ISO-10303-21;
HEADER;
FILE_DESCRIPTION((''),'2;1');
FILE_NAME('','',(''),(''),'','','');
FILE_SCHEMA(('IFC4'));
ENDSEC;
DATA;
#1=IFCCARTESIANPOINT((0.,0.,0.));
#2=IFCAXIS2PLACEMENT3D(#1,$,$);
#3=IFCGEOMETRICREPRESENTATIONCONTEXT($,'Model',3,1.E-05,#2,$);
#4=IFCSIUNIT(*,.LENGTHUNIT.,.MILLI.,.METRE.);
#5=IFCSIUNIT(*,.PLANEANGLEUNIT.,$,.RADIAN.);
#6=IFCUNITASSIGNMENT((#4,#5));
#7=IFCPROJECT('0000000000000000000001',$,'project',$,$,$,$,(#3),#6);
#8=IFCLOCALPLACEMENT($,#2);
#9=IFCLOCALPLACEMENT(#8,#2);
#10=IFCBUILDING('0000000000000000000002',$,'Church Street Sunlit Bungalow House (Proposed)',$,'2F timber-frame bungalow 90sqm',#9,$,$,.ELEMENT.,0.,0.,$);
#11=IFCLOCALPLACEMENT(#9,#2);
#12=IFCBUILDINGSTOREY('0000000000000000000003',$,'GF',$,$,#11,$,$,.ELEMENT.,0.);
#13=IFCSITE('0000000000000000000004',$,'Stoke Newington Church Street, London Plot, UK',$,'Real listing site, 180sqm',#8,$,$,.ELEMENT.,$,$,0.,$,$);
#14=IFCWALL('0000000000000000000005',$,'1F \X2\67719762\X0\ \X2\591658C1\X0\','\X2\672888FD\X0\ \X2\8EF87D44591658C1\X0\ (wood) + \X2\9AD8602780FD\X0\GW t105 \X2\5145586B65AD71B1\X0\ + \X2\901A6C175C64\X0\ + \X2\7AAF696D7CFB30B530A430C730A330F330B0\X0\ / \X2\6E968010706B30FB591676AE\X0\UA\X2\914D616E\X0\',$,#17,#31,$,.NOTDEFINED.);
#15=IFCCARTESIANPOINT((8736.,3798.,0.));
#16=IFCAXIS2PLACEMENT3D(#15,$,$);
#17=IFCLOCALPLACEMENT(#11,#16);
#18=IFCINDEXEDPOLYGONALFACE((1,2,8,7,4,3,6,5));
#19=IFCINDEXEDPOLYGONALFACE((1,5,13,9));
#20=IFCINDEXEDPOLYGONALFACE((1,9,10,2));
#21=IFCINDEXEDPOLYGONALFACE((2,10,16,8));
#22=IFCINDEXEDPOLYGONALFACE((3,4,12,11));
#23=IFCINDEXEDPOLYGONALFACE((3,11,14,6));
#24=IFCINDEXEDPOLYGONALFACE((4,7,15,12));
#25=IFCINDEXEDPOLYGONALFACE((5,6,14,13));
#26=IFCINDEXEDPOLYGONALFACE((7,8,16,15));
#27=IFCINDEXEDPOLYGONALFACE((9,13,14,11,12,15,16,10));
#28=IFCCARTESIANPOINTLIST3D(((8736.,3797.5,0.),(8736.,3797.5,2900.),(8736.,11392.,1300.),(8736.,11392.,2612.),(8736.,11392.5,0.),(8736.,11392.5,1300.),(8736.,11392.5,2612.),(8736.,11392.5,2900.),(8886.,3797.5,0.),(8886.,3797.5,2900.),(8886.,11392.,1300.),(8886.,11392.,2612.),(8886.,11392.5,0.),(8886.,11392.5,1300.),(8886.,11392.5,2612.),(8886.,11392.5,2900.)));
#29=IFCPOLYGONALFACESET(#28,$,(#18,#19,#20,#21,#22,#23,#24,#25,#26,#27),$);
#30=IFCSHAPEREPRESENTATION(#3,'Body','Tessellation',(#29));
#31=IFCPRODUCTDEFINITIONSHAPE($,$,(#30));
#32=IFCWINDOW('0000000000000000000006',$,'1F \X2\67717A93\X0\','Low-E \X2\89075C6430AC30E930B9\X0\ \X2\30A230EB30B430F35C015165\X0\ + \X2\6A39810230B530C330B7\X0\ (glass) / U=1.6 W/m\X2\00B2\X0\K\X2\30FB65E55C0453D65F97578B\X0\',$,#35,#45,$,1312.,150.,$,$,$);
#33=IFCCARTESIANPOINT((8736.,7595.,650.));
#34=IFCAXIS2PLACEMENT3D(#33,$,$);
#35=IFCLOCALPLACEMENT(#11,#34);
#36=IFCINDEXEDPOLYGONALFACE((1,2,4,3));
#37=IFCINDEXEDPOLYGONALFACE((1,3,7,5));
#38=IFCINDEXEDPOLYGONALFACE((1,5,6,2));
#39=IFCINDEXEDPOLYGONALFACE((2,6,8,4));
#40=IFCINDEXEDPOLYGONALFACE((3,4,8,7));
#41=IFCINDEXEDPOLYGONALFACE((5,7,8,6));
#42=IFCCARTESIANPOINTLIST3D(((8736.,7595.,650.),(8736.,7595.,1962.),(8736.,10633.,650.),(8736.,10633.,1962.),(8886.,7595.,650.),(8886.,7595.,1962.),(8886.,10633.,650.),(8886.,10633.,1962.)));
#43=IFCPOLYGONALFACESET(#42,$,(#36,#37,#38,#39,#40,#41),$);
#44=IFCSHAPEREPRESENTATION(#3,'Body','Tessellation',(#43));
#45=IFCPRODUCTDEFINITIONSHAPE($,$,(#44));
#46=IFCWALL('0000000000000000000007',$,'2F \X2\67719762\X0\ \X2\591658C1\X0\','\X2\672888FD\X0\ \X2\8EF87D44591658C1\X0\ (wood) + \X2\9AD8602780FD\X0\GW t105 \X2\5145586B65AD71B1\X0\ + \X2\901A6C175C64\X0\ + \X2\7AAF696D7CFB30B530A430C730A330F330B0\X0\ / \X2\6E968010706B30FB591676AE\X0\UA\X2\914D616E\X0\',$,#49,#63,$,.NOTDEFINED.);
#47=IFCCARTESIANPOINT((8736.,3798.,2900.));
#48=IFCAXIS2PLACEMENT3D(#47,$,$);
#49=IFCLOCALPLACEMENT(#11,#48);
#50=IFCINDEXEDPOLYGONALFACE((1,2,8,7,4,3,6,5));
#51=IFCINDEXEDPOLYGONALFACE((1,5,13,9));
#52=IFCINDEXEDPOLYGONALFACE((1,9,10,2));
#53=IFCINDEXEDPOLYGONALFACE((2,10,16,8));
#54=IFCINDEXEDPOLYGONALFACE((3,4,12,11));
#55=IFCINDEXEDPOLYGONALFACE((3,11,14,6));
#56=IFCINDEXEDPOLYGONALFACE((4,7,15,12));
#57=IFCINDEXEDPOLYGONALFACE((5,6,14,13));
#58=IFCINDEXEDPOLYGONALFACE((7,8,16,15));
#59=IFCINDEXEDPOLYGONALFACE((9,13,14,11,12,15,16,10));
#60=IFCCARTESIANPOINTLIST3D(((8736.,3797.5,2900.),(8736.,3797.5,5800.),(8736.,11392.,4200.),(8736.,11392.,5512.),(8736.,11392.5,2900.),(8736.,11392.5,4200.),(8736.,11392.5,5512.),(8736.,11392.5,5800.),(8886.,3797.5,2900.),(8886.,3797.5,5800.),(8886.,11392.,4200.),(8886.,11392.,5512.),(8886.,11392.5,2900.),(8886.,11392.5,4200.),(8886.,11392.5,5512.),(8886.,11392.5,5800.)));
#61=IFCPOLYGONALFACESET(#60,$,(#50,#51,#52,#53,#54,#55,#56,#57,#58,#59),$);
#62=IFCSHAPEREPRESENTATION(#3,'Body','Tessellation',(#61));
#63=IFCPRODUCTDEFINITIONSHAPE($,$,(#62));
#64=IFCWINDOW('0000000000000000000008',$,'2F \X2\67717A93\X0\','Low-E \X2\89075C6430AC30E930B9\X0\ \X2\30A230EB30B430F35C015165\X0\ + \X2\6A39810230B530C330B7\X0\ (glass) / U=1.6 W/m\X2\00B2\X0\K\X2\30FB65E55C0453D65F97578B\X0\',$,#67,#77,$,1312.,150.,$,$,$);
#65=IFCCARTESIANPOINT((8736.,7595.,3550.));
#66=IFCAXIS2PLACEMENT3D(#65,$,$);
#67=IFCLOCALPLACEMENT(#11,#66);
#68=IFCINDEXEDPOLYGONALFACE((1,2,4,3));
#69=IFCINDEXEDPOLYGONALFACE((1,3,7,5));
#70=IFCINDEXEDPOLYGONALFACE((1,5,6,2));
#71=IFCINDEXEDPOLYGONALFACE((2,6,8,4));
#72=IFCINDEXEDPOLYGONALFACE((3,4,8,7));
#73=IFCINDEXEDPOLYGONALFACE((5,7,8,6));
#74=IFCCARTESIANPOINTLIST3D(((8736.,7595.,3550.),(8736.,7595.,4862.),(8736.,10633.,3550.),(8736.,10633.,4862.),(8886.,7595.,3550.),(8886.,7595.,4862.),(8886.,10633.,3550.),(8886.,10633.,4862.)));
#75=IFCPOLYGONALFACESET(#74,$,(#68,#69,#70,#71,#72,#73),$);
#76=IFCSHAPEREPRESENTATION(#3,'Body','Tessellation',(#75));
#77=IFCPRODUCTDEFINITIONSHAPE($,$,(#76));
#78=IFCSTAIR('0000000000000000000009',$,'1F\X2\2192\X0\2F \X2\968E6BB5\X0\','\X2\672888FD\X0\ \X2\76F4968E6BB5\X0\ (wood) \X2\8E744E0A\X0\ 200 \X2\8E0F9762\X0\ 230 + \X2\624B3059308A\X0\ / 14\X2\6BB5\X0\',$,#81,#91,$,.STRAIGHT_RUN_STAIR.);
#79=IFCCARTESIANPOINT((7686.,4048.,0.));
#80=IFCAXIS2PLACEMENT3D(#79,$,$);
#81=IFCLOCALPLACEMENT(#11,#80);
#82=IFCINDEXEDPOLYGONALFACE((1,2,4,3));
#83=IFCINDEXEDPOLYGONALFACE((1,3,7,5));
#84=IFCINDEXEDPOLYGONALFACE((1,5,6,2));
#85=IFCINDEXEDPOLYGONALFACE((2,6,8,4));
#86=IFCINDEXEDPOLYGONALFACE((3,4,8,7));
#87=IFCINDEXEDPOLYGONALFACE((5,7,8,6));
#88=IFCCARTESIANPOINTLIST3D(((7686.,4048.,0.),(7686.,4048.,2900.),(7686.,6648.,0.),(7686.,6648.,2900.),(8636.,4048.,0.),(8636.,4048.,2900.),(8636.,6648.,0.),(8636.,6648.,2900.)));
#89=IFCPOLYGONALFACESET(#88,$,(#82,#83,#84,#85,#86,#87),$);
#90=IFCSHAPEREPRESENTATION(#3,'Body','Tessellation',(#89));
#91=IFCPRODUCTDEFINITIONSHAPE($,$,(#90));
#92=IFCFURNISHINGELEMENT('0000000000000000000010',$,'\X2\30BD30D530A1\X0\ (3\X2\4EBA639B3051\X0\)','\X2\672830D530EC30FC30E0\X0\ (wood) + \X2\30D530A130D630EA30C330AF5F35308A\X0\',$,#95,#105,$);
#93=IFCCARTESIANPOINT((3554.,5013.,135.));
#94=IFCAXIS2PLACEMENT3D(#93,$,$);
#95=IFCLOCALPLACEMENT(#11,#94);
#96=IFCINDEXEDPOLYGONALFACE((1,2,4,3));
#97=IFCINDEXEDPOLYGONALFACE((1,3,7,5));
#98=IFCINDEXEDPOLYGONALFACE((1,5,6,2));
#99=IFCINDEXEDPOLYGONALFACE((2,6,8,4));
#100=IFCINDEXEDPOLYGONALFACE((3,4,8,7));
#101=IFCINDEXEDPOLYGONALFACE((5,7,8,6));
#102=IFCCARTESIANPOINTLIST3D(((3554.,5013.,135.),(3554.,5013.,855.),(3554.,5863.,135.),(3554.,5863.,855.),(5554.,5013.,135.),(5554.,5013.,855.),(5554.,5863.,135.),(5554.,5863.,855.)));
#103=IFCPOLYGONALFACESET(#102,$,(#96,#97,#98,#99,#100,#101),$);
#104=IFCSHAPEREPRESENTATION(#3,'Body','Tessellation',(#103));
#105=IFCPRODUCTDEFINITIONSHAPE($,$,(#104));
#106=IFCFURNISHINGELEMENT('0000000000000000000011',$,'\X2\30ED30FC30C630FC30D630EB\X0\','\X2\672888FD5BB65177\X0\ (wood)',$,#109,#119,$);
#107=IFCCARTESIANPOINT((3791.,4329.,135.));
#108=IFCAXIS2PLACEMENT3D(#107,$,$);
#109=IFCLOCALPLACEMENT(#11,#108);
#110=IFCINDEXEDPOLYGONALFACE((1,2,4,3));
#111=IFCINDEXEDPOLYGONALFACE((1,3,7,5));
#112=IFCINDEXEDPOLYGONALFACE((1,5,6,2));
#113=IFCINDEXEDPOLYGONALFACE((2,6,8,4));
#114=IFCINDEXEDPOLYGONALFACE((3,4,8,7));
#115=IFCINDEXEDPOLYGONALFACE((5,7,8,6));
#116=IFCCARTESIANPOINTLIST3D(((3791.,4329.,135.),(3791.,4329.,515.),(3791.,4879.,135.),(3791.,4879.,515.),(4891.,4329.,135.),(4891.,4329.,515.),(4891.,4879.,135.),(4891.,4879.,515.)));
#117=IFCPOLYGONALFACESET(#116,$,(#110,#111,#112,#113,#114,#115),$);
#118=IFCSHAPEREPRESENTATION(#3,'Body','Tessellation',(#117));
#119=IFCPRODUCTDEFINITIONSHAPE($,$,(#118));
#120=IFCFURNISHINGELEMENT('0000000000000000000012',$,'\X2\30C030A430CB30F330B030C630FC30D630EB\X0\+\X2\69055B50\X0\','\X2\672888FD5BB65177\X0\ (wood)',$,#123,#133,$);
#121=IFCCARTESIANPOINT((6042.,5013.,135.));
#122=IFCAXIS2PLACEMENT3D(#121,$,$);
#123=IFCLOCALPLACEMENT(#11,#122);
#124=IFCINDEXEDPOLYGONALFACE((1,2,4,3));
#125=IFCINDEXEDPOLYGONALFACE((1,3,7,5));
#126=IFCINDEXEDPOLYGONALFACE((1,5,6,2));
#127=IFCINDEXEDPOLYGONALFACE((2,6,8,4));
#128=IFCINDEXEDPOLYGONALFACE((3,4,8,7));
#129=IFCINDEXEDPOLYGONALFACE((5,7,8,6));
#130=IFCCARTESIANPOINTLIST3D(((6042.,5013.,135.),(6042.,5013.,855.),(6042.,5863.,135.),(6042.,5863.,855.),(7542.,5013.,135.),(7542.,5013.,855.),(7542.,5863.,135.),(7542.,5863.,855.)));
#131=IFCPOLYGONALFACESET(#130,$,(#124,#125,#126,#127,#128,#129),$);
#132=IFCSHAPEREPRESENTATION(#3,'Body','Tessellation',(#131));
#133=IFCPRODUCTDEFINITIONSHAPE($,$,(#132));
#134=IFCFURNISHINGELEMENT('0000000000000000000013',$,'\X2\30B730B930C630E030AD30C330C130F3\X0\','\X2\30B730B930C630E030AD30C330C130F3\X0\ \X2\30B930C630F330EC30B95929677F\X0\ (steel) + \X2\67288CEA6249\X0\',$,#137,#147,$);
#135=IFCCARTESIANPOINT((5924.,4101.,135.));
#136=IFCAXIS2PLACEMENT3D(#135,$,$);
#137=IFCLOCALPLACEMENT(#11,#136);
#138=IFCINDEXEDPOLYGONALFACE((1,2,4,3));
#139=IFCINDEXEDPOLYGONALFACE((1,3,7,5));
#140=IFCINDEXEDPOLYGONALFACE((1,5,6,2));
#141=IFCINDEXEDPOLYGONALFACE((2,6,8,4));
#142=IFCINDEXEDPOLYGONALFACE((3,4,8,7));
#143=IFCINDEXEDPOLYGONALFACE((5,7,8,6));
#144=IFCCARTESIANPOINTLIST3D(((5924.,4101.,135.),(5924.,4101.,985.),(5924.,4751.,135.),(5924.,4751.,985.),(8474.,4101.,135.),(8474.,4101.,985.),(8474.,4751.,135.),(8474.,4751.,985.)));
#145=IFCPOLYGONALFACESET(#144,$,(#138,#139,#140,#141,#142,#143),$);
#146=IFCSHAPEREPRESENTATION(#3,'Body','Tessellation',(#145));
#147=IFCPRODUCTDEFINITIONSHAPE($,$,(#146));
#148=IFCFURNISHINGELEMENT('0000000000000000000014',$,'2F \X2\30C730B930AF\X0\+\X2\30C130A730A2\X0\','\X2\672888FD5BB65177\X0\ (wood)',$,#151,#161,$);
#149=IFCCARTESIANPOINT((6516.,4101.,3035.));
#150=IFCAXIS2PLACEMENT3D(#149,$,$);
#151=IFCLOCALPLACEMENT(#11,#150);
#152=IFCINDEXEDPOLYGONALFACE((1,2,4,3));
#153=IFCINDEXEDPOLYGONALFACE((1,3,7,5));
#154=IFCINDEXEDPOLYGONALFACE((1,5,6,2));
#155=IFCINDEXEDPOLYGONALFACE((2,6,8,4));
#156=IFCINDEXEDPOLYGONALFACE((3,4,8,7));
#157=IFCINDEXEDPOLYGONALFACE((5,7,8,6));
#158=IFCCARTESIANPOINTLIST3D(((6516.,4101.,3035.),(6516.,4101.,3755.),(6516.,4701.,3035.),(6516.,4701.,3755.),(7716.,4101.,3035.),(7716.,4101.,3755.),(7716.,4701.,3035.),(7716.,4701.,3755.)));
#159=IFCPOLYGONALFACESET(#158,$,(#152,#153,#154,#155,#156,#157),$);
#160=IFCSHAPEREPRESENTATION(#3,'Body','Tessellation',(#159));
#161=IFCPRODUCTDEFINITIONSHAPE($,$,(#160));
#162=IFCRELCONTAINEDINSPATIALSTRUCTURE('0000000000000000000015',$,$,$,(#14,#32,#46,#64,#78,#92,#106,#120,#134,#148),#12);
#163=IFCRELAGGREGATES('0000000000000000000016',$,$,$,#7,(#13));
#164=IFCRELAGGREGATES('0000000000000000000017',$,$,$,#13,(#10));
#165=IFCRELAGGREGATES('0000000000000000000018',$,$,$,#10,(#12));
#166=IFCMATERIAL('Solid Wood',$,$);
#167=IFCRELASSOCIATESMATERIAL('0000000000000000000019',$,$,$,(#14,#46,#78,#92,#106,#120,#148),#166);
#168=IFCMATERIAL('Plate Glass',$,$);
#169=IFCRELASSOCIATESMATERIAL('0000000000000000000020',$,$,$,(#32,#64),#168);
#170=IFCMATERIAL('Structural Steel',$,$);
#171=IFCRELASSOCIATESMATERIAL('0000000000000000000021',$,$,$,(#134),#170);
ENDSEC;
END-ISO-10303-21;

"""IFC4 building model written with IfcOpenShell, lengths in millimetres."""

from ifc_helpers import new_model, si_unit, frame, frame_2d, origin, place, context, project, spatial, rectangle, extrude, material, element, fill, save


model = new_model("IFC4")

# Units and contexts
model_context = context("Model", 3, precision=1e-05, world=origin())
ifc_project = project(units=[si_unit("LENGTHUNIT", "METRE", prefix="MILLI"), si_unit("PLANEANGLEUNIT", "RADIAN")], contexts=[model_context])

# Site, building, storey
site_placement = place(None, origin())
site = spatial("IfcSite", under=ifc_project, at=site_placement, Name="Stoke Newington Church Street, London Plot, UK", ObjectType="Real listing site, 180sqm", CompositionType="ELEMENT", RefElevation=0.0)
building_placement = place(site_placement, origin())
building = spatial("IfcBuilding", under=site, at=building_placement, Name="Church Street Sunlit Bungalow House (Proposed)", ObjectType="2F timber-frame bungalow 90sqm", CompositionType="ELEMENT", ElevationOfRefHeight=0.0, ElevationOfTerrain=0.0)
storey_placement = place(building_placement, origin())
storey = spatial("IfcBuildingStorey", under=building, at=storey_placement, Name="GF", CompositionType="ELEMENT", Elevation=0.0)

# Wall, opening, window
ifc_material_1 = material(Name="Solid Wood")
wall_1_placement = place(storey_placement, frame((8736.0, 3798.0, 0.0)))
wall_1 = element("IfcWall", 1, at=wall_1_placement, inside=storey, material=ifc_material_1, Name="1F 東面 外壁", Description="木製 軸組外壁 (wood) + 高性能GW t105 充填断熱 + 通気層 + 窯業系サイディング / 準耐火・外皮UA配慮", PredefinedType="NOTDEFINED", context=model_context, shape_type="SweptSolid", body=[
    extrude(rectangle(XDim=150.0, YDim=7595.0, at=frame_2d((75.0, 3797.0))), frame((8736.0, 3798.0, 0.0)), (0.0, 0.0, 1.0), 2900.0),
])
opening_1_placement = place(storey_placement, frame((8736.0, 7595.0, 650.0)))
opening_1 = element("IfcOpeningElement", 2, at=opening_1_placement, cuts=wall_1, PredefinedType="NOTDEFINED", context=model_context, shape_type="SweptSolid", body=[
    extrude(rectangle(XDim=150.0, YDim=3038.0, at=frame_2d((75.0, 1519.0))), frame((8736.0, 7595.0, 650.0)), (0.0, 0.0, 1.0), 1312.0),
])
ifc_material_2 = material(Name="Plate Glass")
window_1_placement = place(storey_placement, frame((8736.0, 7595.0, 650.0)))
window_1 = element("IfcWindow", 3, at=window_1_placement, inside=storey, material=ifc_material_2, Name="1F 東窓", Description="Low-E 複層ガラス アルゴン封入 + 樹脂サッシ (glass) / U=1.6 W/m²K・日射取得型", OverallHeight=1312.0, OverallWidth=150.0, context=model_context, shape_type="SweptSolid", body=[
    extrude(rectangle(XDim=150.0, YDim=3038.0, at=frame_2d((75.0, 1519.0))), frame((8736.0, 7595.0, 650.0)), (0.0, 0.0, 1.0), 1312.0),
])
fill(opening_1, window_1)

# Wall, opening, window
wall_2_placement = place(storey_placement, frame((8736.0, 3798.0, 2900.0)))
wall_2 = element("IfcWall", 4, at=wall_2_placement, inside=storey, material=ifc_material_1, Name="2F 東面 外壁", Description="木製 軸組外壁 (wood) + 高性能GW t105 充填断熱 + 通気層 + 窯業系サイディング / 準耐火・外皮UA配慮", PredefinedType="NOTDEFINED", context=model_context, shape_type="SweptSolid", body=[
    extrude(rectangle(XDim=150.0, YDim=7595.0, at=frame_2d((75.0, 3797.0))), frame((8736.0, 3798.0, 2900.0)), (0.0, 0.0, 1.0), 2900.0),
])
opening_2_placement = place(storey_placement, frame((8736.0, 7595.0, 3550.0)))
opening_2 = element("IfcOpeningElement", 5, at=opening_2_placement, cuts=wall_2, PredefinedType="NOTDEFINED", context=model_context, shape_type="SweptSolid", body=[
    extrude(rectangle(XDim=150.0, YDim=3038.0, at=frame_2d((75.0, 1519.0))), frame((8736.0, 7595.0, 3550.0)), (0.0, 0.0, 1.0), 1312.0),
])
window_2_placement = place(storey_placement, frame((8736.0, 7595.0, 3550.0)))
window_2 = element("IfcWindow", 6, at=window_2_placement, inside=storey, material=ifc_material_2, Name="2F 東窓", Description="Low-E 複層ガラス アルゴン封入 + 樹脂サッシ (glass) / U=1.6 W/m²K・日射取得型", OverallHeight=1312.0, OverallWidth=150.0, context=model_context, shape_type="SweptSolid", body=[
    extrude(rectangle(XDim=150.0, YDim=3038.0, at=frame_2d((75.0, 1519.0))), frame((8736.0, 7595.0, 3550.0)), (0.0, 0.0, 1.0), 1312.0),
])
fill(opening_2, window_2)

# Stair
stair_placement = place(storey_placement, frame((7686.0, 4048.0, 0.0)))
element("IfcStair", 7, at=stair_placement, inside=storey, material=ifc_material_1, Name="1F→2F 階段", Description="木製 直階段 (wood) 蹴上 200 踏面 230 + 手すり / 14段", PredefinedType="STRAIGHT_RUN_STAIR", context=model_context, shape_type="SweptSolid", body=[
    extrude(rectangle(XDim=950.0, YDim=2600.0, at=frame_2d((475.0, 1300.0))), frame((7686.0, 4048.0, 0.0)), (0.0, 0.0, 1.0), 2900.0),
])

# Furnishing elements
furnishing_1_placement = place(storey_placement, frame((3554.0, 5013.0, 135.0)))
element("IfcFurnishingElement", 8, at=furnishing_1_placement, inside=storey, material=ifc_material_1, Name="ソファ (3人掛け)", Description="木フレーム (wood) + ファブリック張り", context=model_context, shape_type="SweptSolid", body=[
    extrude(rectangle(XDim=2000.0, YDim=850.0, at=frame_2d((1000.0, 425.0))), frame((3554.0, 5013.0, 135.0)), (0.0, 0.0, 1.0), 720.0),
])
furnishing_2_placement = place(storey_placement, frame((3791.0, 4329.0, 135.0)))
element("IfcFurnishingElement", 9, at=furnishing_2_placement, inside=storey, material=ifc_material_1, Name="ローテーブル", Description="木製家具 (wood)", context=model_context, shape_type="SweptSolid", body=[
    extrude(rectangle(XDim=1100.0, YDim=550.0, at=frame_2d((550.0, 275.0))), frame((3791.0, 4329.0, 135.0)), (0.0, 0.0, 1.0), 380.0),
])
furnishing_3_placement = place(storey_placement, frame((6042.0, 5013.0, 135.0)))
element("IfcFurnishingElement", 10, at=furnishing_3_placement, inside=storey, material=ifc_material_1, Name="ダイニングテーブル+椅子", Description="木製家具 (wood)", context=model_context, shape_type="SweptSolid", body=[
    extrude(rectangle(XDim=1500.0, YDim=850.0, at=frame_2d((750.0, 425.0))), frame((6042.0, 5013.0, 135.0)), (0.0, 0.0, 1.0), 720.0),
])
ifc_material_3 = material(Name="Structural Steel")
furnishing_4_placement = place(storey_placement, frame((5924.0, 4101.0, 135.0)))
element("IfcFurnishingElement", 11, at=furnishing_4_placement, inside=storey, material=ifc_material_3, Name="システムキッチン", Description="システムキッチン ステンレス天板 (steel) + 木質扉", context=model_context, shape_type="SweptSolid", body=[
    extrude(rectangle(XDim=2550.0, YDim=650.0, at=frame_2d((1275.0, 325.0))), frame((5924.0, 4101.0, 135.0)), (0.0, 0.0, 1.0), 850.0),
])
furnishing_5_placement = place(storey_placement, frame((6516.0, 4101.0, 3035.0)))
element("IfcFurnishingElement", 12, at=furnishing_5_placement, inside=storey, material=ifc_material_1, Name="2F デスク+チェア", Description="木製家具 (wood)", context=model_context, shape_type="SweptSolid", body=[
    extrude(rectangle(XDim=1200.0, YDim=600.0, at=frame_2d((600.0, 300.0))), frame((6516.0, 4101.0, 3035.0)), (0.0, 0.0, 1.0), 720.0),
])

save(model, "model.ifc")
